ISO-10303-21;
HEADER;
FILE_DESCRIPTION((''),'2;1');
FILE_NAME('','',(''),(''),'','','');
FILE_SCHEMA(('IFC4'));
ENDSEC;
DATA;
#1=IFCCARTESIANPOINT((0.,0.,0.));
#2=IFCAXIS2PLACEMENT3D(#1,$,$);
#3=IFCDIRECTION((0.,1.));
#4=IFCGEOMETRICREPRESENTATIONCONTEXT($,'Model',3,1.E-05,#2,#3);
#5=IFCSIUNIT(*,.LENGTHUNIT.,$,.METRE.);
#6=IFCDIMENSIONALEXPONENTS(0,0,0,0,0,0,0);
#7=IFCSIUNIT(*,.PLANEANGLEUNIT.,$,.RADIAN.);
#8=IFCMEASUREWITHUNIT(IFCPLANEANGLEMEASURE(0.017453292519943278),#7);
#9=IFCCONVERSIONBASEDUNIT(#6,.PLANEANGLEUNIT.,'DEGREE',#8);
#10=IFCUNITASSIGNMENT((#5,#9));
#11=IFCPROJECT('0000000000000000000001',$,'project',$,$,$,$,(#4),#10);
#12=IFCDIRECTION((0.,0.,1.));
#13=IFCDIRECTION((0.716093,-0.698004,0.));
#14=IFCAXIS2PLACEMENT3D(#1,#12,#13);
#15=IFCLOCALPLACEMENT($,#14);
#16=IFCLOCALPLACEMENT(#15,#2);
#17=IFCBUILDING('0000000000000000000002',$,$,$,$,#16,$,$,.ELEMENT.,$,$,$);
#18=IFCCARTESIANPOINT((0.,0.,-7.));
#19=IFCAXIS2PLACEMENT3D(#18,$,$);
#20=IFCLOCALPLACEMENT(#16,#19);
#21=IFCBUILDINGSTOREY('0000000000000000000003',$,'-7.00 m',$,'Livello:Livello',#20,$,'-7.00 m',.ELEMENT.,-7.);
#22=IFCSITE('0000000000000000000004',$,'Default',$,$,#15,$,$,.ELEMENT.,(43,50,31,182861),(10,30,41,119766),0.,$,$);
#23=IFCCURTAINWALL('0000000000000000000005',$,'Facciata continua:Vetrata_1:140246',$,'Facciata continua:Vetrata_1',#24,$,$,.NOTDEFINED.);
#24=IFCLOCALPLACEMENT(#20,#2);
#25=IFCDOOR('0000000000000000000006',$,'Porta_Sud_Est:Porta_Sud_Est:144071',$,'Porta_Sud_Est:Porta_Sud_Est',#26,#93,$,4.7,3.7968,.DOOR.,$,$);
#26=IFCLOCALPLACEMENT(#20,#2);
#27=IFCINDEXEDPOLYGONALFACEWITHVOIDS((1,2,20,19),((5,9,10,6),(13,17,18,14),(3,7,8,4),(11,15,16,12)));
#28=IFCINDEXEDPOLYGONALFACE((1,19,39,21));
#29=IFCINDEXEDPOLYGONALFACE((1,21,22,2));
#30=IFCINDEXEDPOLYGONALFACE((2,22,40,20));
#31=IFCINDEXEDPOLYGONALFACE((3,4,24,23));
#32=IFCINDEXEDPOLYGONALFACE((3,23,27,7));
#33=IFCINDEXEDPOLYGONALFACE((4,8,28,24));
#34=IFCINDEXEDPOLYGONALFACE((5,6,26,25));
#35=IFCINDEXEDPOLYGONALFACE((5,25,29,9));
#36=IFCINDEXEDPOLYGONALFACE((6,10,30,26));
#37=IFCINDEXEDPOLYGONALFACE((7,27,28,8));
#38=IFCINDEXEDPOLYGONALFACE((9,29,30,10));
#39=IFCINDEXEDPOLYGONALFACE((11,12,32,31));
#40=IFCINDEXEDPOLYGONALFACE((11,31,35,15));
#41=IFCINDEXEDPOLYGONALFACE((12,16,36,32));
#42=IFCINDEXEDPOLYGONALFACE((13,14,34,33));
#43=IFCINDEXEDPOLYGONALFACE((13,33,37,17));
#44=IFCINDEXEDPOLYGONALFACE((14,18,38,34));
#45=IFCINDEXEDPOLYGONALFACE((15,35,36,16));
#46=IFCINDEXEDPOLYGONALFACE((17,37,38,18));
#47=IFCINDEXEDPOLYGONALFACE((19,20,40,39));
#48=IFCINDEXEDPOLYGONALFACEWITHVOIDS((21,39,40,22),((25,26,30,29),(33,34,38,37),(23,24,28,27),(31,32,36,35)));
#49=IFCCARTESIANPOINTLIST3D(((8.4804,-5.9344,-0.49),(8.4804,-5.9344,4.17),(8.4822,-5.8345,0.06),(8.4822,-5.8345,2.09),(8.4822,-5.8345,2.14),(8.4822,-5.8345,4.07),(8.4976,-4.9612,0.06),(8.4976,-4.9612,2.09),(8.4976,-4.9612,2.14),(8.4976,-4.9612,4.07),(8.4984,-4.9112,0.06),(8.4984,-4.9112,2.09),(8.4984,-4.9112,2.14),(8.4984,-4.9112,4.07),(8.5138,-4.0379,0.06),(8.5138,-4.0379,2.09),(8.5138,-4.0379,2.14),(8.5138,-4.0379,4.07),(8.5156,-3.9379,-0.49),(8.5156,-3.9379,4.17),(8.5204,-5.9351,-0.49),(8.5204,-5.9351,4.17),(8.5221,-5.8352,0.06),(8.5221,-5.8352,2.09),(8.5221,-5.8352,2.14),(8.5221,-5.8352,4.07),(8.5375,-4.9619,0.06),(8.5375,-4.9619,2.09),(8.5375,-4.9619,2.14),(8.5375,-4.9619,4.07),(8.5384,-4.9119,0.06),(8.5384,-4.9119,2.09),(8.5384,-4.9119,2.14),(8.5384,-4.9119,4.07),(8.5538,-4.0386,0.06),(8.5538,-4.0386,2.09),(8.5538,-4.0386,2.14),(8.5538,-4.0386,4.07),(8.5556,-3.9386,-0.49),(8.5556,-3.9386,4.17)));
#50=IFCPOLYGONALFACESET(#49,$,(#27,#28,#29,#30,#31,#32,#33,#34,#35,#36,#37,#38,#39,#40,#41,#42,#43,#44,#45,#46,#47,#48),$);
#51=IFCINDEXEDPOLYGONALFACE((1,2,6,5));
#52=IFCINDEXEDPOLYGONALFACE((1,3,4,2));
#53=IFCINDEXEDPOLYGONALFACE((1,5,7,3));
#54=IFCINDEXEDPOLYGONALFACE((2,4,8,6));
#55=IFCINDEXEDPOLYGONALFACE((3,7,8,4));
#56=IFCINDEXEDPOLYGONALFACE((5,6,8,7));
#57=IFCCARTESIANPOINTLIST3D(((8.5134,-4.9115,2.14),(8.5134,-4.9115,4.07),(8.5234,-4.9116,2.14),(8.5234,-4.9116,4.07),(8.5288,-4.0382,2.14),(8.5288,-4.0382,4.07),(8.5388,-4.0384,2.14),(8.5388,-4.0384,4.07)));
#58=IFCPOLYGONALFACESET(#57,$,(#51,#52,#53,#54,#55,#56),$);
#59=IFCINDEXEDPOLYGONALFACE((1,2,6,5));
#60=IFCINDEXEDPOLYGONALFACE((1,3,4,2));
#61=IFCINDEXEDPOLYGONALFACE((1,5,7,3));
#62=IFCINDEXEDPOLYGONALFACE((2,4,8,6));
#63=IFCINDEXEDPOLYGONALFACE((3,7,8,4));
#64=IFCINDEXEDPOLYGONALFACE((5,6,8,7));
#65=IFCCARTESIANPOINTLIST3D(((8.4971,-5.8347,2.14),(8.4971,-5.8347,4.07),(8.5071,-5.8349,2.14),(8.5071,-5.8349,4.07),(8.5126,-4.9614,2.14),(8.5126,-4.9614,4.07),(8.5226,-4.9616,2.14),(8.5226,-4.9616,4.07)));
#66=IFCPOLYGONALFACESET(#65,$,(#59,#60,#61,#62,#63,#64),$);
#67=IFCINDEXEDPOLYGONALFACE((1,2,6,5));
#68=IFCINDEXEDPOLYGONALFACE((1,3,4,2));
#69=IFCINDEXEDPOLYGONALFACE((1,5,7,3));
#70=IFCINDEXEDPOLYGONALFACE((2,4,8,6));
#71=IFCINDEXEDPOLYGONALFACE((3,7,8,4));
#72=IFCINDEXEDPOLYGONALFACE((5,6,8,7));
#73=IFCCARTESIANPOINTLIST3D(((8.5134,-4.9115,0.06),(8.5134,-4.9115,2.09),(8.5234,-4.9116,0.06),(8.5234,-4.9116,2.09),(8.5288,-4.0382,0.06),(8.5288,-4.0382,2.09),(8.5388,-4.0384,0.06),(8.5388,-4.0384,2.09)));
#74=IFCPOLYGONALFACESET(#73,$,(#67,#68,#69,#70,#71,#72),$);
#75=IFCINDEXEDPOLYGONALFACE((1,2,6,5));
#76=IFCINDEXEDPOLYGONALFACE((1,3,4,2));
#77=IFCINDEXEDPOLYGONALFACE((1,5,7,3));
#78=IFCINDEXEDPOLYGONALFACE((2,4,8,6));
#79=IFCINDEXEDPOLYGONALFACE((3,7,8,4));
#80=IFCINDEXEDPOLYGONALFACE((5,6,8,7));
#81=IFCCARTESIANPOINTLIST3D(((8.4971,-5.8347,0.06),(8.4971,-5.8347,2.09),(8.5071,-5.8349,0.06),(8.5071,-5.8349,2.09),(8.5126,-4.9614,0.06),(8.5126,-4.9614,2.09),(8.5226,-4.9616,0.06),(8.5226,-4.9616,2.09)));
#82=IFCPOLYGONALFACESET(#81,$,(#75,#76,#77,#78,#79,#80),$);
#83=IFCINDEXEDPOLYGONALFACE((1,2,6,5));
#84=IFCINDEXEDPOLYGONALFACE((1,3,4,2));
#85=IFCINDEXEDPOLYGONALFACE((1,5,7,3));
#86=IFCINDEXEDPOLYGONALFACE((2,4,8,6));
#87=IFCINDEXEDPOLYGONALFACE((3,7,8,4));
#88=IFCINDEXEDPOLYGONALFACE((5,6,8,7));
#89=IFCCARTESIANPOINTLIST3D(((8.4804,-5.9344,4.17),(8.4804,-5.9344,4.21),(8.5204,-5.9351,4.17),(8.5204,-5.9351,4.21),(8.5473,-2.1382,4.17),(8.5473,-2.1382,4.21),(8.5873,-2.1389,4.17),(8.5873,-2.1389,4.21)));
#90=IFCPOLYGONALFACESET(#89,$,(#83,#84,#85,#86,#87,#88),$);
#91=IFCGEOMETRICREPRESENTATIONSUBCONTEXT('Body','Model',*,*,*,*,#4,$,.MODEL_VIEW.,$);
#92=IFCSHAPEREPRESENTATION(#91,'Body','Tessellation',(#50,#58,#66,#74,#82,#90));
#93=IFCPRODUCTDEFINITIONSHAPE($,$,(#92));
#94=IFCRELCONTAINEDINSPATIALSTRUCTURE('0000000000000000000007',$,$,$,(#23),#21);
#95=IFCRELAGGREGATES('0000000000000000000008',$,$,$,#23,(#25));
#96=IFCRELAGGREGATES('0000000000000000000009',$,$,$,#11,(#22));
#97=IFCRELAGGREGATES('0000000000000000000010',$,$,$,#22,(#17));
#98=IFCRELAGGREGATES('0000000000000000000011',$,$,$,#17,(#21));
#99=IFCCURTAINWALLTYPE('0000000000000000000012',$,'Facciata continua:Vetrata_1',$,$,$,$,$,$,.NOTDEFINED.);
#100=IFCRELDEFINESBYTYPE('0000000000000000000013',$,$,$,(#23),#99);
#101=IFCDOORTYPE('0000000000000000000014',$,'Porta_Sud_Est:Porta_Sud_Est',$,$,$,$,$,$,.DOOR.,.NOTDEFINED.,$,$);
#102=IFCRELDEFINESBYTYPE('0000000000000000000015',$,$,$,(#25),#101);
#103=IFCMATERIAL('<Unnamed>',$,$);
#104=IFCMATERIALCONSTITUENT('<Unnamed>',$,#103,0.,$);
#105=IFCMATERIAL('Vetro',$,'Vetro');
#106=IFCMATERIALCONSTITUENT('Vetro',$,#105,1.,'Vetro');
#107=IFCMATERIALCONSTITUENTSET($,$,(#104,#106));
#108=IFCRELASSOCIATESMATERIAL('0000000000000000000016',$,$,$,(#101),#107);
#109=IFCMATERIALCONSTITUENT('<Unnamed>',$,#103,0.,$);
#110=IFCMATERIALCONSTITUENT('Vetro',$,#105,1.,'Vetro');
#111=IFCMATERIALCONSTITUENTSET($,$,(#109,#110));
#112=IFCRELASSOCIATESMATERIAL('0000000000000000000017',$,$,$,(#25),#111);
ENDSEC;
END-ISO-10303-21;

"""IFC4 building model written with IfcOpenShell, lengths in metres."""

from ifc_helpers import new_model, entity, si_unit, converted_unit, direction, frame, origin, place, context, subcontext, project, spatial, indexed_curve, outline, extrude, source, transform, mapped, material, constituent, constituent_set, type_object, type_shapes, element, aggregate, save


model = new_model("IFC4")

# Units and contexts
model_context = context("Model", 3, precision=1e-05, world=origin(), true_north=direction((0.0, 1.0)))
body_context = subcontext(model_context, "Body", "Model", "MODEL_VIEW")
ifc_project = project(units=[si_unit("LENGTHUNIT", "METRE"), converted_unit("PLANEANGLEUNIT", "DEGREE", entity("IfcPlaneAngleMeasure", 0.017453292519943278), si_unit("PLANEANGLEUNIT", "RADIAN"), dimensions=[0, 0, 0, 0, 0, 0, 0])], contexts=[model_context])

# Site, building, storey
site_placement = place(None, frame((0.0, 0.0, 0.0), z_axis=(0.0, 0.0, 1.0), x_axis=(0.716093, -0.698004, 0.0)))
site = spatial("IfcSite", under=ifc_project, at=site_placement, Name="Default", CompositionType="ELEMENT", RefLatitude=(43, 50, 31, 182861), RefLongitude=(10, 30, 41, 119766), RefElevation=0.0)
building_placement = place(site_placement, origin())
building = spatial("IfcBuilding", under=site, at=building_placement, CompositionType="ELEMENT")
storey_placement = place(building_placement, frame((0.0, 0.0, -7.0)))
storey = spatial("IfcBuildingStorey", under=building, at=storey_placement, Name="-7.00 m", ObjectType="Livello:Livello", LongName="-7.00 m", CompositionType="ELEMENT", Elevation=-7.0)

# Curtain wall
curtain_wall_type_1 = type_object("IfcCurtainWallType", Name="Facciata continua:Vetrata_1", PredefinedType="NOTDEFINED")
curtain_wall_1_placement = place(storey_placement, frame((0.0, 0.0, 7.0)))
curtain_wall_1 = element("IfcCurtainWall", 1, at=curtain_wall_1_placement, inside=storey, type_object=curtain_wall_type_1, Name="Facciata continua:Vetrata_1:140246", ObjectType="Facciata continua:Vetrata_1", PredefinedType="NOTDEFINED")

# Door
ifc_material_1 = material(Name="<Unnamed>")
ifc_constituent_1 = constituent(ifc_material_1, Name="<Unnamed>", fraction=0.0)
ifc_material_2 = material(Name="Vetro", Category="Vetro")
ifc_constituent_2 = constituent(ifc_material_2, Name="Vetro", Category="Vetro", fraction=1.0)
ifc_constituent_set_1 = constituent_set(constituents=[ifc_constituent_1, ifc_constituent_2])
ifc_constituent_3 = constituent(ifc_material_1, Name="<Unnamed>", fraction=0.0)
ifc_constituent_4 = constituent(ifc_material_2, Name="Vetro", Category="Vetro", fraction=1.0)
ifc_constituent_set_2 = constituent_set(constituents=[ifc_constituent_3, ifc_constituent_4])
door_type = type_object("IfcDoorType", Name="Porta_Sud_Est:Porta_Sud_Est", OperationType="NOTDEFINED", PredefinedType="DOOR", material=ifc_constituent_set_2)
shared_shape_1 = source(origin(), body_context, "Body", "SweptSolid", [
    extrude(outline(indexed_curve([(-0.9984, -2.33), (0.9984, -2.33), (0.9984, 2.33), (-0.9984, 2.33), (-0.9984, -2.33)], self_intersect=False), holes=[indexed_curve([(0.025, -0.3), (0.8984, -0.3), (0.8984, -2.23), (0.025, -2.23), (0.025, -0.3)], self_intersect=False), indexed_curve([(-0.8984, -0.3), (-0.025, -0.3), (-0.025, -2.23), (-0.8984, -2.23), (-0.8984, -0.3)], self_intersect=False), indexed_curve([(0.025, -0.25), (0.025, 1.78), (0.8984, 1.78), (0.8984, -0.25), (0.025, -0.25)], self_intersect=False), indexed_curve([(-0.025, 1.78), (-0.025, -0.25), (-0.8984, -0.25), (-0.8984, 1.78), (-0.025, 1.78)], self_intersect=False)]), frame((0.0, -0.16, 1.78), z_axis=(0.0, 1.0, 0.0), x_axis=(1.0, 0.0, 0.0)), (0.0, 0.0, 1.0), 0.04),
    extrude(outline(indexed_curve([(-0.4367, -0.005), (0.4367, -0.005), (0.4367, 0.005), (-0.4367, 0.005), (-0.4367, -0.005)], self_intersect=False)), frame((0.4617, -0.14, 2.08), z_axis=(0.0, 0.0, 1.0), x_axis=(-1.0, 0.0, 0.0)), (0.0, 0.0, 1.0), 1.93),
    extrude(outline(indexed_curve([(-0.4367, -0.005), (0.4367, -0.005), (0.4367, 0.005), (-0.4367, 0.005), (-0.4367, -0.005)], self_intersect=False)), frame((-0.4617, -0.14, 2.08), z_axis=(0.0, 0.0, 1.0), x_axis=(-1.0, 0.0, 0.0)), (0.0, 0.0, 1.0), 1.93),
    extrude(outline(indexed_curve([(-0.4367, -0.005), (0.4367, -0.005), (0.4367, 0.005), (-0.4367, 0.005), (-0.4367, -0.005)], self_intersect=False)), frame((0.4617, -0.14, 0.0), z_axis=(0.0, 0.0, 1.0), x_axis=(-1.0, 0.0, 0.0)), (0.0, 0.0, 1.0), 2.03),
    extrude(outline(indexed_curve([(-0.4367, -0.005), (0.4367, -0.005), (0.4367, 0.005), (-0.4367, 0.005), (-0.4367, -0.005)], self_intersect=False)), frame((-0.4617, -0.14, 0.0), z_axis=(0.0, 0.0, 1.0), x_axis=(-1.0, 0.0, 0.0)), (0.0, 0.0, 1.0), 2.03),
    extrude(outline(indexed_curve([(-1.8984, -0.02), (1.8984, -0.02), (1.8984, 0.02), (-1.8984, 0.02), (-1.8984, -0.02)], self_intersect=False)), frame((0.9, -0.14, 4.11), z_axis=(0.0, 0.0, 1.0), x_axis=(-1.0, 0.0, 0.0)), (0.0, 0.0, 1.0), 0.04),
])
type_shapes(door_type, [shared_shape_1])
door_placement = place(curtain_wall_1_placement, frame((8.378, -4.9341, -6.94), z_axis=(0.0, 0.0, 1.0), x_axis=(0.017636, 0.999844, 0.0)))
door = element("IfcDoor", 2, at=door_placement, type_object=door_type, material=ifc_constituent_set_1, Name="Porta_Sud_Est:Porta_Sud_Est:144071", ObjectType="Porta_Sud_Est:Porta_Sud_Est", OverallHeight=4.7, OverallWidth=3.7968, PredefinedType="DOOR", context=body_context, shape_type="MappedRepresentation", body=[
    mapped(shared_shape_1, transform((0.0, 0.0, 0.0), scale=1.0)),
])
aggregate(curtain_wall_1, [door])

save(model, "model.ifc")
